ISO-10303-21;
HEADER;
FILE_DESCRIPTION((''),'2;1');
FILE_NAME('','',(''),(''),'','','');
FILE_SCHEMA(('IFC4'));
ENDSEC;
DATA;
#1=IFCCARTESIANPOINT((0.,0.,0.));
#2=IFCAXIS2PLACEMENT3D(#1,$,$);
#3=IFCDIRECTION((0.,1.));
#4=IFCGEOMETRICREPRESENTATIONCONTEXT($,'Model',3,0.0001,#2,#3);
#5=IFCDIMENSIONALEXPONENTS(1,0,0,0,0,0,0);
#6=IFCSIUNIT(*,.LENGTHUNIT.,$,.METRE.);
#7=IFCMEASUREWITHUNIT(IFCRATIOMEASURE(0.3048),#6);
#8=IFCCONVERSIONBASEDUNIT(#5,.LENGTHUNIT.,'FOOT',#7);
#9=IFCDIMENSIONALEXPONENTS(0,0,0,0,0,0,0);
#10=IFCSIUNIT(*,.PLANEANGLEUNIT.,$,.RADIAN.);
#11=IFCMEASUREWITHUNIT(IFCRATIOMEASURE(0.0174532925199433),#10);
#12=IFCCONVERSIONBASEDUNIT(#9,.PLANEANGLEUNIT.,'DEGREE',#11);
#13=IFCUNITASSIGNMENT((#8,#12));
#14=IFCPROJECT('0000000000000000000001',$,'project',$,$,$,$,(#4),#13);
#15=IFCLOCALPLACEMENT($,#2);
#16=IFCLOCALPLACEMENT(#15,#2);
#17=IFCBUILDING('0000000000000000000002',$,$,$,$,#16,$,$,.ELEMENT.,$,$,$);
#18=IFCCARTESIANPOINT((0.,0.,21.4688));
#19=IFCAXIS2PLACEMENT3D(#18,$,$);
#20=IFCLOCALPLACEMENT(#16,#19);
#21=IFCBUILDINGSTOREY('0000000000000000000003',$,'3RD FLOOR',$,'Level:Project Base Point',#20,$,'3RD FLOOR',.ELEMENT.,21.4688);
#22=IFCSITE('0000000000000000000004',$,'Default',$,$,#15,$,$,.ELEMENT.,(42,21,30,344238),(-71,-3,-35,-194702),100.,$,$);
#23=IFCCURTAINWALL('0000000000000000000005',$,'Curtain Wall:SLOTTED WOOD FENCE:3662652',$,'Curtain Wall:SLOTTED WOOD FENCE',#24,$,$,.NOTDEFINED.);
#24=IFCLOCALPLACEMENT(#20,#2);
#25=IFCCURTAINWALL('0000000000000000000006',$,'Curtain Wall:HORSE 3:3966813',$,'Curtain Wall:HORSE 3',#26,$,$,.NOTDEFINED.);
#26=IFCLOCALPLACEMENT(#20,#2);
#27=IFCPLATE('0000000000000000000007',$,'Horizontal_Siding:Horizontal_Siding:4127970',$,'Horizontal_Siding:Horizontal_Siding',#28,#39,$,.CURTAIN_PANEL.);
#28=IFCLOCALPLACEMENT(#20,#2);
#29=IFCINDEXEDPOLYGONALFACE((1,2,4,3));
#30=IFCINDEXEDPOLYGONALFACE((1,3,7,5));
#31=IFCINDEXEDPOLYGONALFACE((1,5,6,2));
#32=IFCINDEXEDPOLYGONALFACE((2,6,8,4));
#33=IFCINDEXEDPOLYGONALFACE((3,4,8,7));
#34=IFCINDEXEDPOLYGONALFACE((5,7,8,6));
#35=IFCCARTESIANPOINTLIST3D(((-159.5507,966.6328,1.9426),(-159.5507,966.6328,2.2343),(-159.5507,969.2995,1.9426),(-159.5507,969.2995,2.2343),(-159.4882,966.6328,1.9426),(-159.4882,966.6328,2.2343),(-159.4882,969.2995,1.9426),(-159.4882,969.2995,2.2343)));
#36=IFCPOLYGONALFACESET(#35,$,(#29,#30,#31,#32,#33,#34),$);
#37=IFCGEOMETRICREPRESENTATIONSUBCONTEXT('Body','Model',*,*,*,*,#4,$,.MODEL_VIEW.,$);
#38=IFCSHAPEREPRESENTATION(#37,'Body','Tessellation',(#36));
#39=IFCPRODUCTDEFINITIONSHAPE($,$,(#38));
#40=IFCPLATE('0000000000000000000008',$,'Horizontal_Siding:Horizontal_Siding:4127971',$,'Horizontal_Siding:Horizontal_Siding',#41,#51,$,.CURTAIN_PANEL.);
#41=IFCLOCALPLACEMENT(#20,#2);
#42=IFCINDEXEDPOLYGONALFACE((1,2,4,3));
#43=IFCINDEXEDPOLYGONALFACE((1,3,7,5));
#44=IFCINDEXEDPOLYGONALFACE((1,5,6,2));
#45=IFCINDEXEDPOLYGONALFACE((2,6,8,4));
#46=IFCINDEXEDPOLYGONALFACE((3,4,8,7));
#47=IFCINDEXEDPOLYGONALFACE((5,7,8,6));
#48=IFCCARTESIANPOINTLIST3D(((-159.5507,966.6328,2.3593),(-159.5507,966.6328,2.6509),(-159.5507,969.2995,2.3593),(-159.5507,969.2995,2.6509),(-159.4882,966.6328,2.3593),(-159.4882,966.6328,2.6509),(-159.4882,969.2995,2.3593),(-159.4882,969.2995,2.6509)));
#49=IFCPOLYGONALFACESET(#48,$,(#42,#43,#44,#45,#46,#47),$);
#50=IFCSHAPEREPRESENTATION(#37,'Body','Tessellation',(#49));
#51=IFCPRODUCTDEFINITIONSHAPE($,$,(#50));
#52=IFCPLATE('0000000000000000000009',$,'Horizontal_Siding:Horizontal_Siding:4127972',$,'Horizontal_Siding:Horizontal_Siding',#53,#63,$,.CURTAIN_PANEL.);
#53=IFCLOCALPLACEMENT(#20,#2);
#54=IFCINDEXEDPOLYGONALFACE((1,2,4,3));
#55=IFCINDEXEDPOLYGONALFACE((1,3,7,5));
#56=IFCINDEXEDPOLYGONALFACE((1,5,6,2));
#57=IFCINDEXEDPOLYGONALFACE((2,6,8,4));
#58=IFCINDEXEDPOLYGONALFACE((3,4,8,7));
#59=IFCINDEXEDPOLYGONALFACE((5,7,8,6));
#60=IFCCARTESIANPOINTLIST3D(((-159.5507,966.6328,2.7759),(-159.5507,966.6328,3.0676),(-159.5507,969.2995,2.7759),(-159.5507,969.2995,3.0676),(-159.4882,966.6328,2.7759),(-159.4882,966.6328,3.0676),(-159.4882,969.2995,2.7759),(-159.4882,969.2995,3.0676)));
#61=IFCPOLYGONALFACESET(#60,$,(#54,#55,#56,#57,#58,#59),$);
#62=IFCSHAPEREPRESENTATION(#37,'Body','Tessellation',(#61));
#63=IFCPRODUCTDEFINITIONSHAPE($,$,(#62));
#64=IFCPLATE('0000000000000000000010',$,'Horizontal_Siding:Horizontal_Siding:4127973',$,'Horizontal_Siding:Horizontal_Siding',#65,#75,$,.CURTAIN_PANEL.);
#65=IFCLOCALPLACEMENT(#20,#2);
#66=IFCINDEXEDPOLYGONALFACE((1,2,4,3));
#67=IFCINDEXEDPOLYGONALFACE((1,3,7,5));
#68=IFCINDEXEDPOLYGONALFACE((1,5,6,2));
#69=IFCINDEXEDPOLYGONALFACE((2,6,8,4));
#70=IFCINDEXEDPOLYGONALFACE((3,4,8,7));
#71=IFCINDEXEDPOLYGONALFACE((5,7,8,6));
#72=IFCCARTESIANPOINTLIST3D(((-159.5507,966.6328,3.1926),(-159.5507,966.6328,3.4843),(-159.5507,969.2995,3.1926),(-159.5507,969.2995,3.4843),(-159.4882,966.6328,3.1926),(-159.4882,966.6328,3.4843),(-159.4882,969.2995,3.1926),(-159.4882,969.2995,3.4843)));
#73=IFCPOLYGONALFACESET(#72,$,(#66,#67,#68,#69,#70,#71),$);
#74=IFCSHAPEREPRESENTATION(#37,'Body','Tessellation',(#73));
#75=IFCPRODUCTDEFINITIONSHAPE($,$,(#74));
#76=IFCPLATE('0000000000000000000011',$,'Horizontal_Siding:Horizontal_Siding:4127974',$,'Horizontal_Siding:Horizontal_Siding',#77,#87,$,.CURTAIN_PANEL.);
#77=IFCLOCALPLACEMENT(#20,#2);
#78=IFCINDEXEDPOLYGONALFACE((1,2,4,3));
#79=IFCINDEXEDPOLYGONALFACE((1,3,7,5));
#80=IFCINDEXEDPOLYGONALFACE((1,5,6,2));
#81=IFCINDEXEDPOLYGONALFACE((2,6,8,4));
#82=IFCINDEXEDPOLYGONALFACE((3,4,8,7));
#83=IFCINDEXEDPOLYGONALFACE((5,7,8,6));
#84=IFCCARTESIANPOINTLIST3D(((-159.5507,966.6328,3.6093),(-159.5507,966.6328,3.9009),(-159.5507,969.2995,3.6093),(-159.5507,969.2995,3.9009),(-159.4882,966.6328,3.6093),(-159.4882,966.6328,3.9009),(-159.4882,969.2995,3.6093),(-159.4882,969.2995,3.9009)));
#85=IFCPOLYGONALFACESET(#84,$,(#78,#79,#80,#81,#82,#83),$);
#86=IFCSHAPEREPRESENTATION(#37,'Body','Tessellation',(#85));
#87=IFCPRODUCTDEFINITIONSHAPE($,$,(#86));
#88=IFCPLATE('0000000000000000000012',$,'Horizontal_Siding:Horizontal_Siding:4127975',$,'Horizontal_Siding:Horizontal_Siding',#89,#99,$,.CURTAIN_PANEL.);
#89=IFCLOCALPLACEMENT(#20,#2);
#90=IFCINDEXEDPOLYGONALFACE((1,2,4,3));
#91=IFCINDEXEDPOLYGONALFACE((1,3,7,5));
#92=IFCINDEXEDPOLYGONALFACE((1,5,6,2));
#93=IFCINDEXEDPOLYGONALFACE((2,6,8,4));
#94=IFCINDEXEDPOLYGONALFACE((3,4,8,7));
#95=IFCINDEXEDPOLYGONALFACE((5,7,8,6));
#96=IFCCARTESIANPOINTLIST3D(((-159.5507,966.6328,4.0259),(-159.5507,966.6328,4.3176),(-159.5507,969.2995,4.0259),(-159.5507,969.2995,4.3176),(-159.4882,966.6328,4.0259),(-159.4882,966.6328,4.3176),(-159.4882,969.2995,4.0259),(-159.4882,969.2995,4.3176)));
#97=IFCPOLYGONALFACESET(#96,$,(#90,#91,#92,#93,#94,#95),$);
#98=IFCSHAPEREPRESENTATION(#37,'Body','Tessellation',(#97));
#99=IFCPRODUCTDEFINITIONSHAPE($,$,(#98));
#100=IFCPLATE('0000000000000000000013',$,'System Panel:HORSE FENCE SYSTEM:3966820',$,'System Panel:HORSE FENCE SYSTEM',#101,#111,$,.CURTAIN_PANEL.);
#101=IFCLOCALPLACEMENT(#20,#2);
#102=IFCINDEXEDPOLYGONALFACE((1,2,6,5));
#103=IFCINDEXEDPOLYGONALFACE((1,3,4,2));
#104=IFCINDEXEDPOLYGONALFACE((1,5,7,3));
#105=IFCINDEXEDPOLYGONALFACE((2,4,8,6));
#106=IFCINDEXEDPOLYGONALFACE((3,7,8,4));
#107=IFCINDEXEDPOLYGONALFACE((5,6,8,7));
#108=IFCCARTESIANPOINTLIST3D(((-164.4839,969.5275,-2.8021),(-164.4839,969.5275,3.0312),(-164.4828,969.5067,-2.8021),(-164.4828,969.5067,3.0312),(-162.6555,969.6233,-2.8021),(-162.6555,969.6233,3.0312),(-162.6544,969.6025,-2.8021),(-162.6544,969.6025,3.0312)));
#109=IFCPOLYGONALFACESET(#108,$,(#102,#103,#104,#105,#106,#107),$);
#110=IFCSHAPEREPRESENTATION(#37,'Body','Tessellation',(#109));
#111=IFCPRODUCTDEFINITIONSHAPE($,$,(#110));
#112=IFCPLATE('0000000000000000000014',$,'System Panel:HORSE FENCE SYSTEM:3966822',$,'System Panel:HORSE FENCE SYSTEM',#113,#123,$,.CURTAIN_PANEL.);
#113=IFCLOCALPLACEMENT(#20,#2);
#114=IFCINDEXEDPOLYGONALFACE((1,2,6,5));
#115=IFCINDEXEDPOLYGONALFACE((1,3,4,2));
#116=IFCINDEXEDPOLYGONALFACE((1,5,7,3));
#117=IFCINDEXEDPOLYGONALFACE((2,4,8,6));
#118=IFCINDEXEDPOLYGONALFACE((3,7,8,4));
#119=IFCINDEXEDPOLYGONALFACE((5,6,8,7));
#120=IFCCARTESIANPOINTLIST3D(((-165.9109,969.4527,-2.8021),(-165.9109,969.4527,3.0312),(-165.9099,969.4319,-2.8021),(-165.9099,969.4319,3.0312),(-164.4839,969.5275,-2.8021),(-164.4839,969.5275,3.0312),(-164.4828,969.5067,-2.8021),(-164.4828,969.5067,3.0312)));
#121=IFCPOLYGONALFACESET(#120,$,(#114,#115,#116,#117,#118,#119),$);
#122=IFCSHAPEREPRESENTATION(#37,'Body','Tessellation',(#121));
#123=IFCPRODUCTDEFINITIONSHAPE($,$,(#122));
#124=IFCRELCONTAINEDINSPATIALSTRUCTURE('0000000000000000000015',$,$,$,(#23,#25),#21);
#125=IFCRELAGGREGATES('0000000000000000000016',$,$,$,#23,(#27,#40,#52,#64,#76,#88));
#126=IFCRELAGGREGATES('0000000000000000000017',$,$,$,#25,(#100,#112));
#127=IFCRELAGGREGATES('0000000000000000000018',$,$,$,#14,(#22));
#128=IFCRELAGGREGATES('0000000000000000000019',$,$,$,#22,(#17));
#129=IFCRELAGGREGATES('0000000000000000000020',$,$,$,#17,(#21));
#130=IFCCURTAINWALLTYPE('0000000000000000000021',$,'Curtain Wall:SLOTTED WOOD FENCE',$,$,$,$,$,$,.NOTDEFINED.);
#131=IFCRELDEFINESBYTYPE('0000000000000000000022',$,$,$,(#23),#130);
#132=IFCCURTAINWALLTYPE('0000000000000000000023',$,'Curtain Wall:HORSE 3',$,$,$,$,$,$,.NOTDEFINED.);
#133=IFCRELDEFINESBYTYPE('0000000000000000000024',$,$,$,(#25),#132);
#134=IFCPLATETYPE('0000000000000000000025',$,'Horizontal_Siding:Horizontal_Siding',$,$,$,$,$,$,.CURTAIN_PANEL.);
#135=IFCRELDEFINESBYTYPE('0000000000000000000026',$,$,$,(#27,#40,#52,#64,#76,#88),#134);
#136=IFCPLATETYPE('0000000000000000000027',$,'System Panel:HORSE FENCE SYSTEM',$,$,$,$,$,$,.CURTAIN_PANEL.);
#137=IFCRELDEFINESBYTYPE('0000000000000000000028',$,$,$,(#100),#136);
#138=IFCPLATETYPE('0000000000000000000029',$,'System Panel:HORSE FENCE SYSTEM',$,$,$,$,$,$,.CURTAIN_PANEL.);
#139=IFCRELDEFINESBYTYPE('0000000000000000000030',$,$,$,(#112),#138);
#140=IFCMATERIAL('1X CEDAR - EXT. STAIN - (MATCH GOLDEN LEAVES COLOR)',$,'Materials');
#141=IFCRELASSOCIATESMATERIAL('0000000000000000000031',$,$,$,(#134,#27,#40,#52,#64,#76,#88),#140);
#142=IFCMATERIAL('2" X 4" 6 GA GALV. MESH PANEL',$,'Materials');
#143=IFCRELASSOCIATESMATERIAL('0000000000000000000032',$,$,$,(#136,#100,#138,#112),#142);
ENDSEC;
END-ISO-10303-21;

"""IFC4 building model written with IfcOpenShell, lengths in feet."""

from ifc_helpers import new_model, entity, si_unit, converted_unit, direction, frame, frame_2d, origin, origin_2d_with_axis, place, context, subcontext, project, spatial, rectangle, extrude, source, transform, mapped, material, type_object, type_shapes, element, aggregate, save


model = new_model("IFC4")

# Units and contexts
model_context = context("Model", 3, precision=0.0001, world=origin(), true_north=direction((0.0, 1.0)))
body_context = subcontext(model_context, "Body", "Model", "MODEL_VIEW")
ifc_project = project(units=[converted_unit("LENGTHUNIT", "FOOT", entity("IfcRatioMeasure", 0.3048), si_unit("LENGTHUNIT", "METRE"), dimensions=[1, 0, 0, 0, 0, 0, 0]), converted_unit("PLANEANGLEUNIT", "DEGREE", entity("IfcRatioMeasure", 0.0174532925199433), si_unit("PLANEANGLEUNIT", "RADIAN"), dimensions=[0, 0, 0, 0, 0, 0, 0])], contexts=[model_context])

# Site, building, storey
site_placement = place(None, origin())
site = spatial("IfcSite", under=ifc_project, at=site_placement, Name="Default", CompositionType="ELEMENT", RefLatitude=(42, 21, 30, 344238), RefLongitude=(-71, -3, -35, -194702), RefElevation=100.0)
building_placement = place(site_placement, origin())
building = spatial("IfcBuilding", under=site, at=building_placement, CompositionType="ELEMENT")
storey_placement = place(building_placement, frame((0.0, 0.0, 21.4688)))
storey = spatial("IfcBuildingStorey", under=building, at=storey_placement, Name="3RD FLOOR", ObjectType="Level:Project Base Point", LongName="3RD FLOOR", CompositionType="ELEMENT", Elevation=21.4688)

# Curtain wall
curtain_wall_type_1 = type_object("IfcCurtainWallType", Name="Curtain Wall:SLOTTED WOOD FENCE", PredefinedType="NOTDEFINED")
curtain_wall_1_placement = place(storey_placement, frame((0.0, 0.0, -21.4688)))
curtain_wall_1 = element("IfcCurtainWall", 1, at=curtain_wall_1_placement, inside=storey, type_object=curtain_wall_type_1, Name="Curtain Wall:SLOTTED WOOD FENCE:3662652", ObjectType="Curtain Wall:SLOTTED WOOD FENCE", PredefinedType="NOTDEFINED")

# Curtain wall
curtain_wall_type_2 = type_object("IfcCurtainWallType", Name="Curtain Wall:HORSE 3", PredefinedType="NOTDEFINED")
curtain_wall_2_placement = place(storey_placement, frame((0.0, 0.0, -21.4688)))
curtain_wall_2 = element("IfcCurtainWall", 2, at=curtain_wall_2_placement, inside=storey, type_object=curtain_wall_type_2, Name="Curtain Wall:HORSE 3:3966813", ObjectType="Curtain Wall:HORSE 3", PredefinedType="NOTDEFINED")

# Plates
ifc_material_1 = material(Name="1X CEDAR - EXT. STAIN - (MATCH GOLDEN LEAVES COLOR)", Category="Materials")
plate_type_1 = type_object("IfcPlateType", Name="Horizontal_Siding:Horizontal_Siding", PredefinedType="CURTAIN_PANEL", material=ifc_material_1)
shared_shape_1 = source(origin(), body_context, "Body", "SweptSolid", [
    extrude(rectangle(XDim=2.6667, YDim=0.0625, at=origin_2d_with_axis()), frame((1.3333, 0.0312, 0.0), z_axis=(0.0, 0.0, 1.0), x_axis=(-1.0, 0.0, 0.0)), (0.0, 0.0, 1.0), 0.2917),
])
type_shapes(plate_type_1, [shared_shape_1])
plate_1_placement = place(curtain_wall_1_placement, frame((-159.5507, 969.2995, 23.4113), z_axis=(0.0, 0.0, 1.0), x_axis=(0.0, -1.0, 0.0)))
plate_1 = element("IfcPlate", 3, at=plate_1_placement, type_object=plate_type_1, material=ifc_material_1, Name="Horizontal_Siding:Horizontal_Siding:4127970", ObjectType="Horizontal_Siding:Horizontal_Siding", PredefinedType="CURTAIN_PANEL", context=body_context, shape_type="MappedRepresentation", body=[
    mapped(shared_shape_1, transform((0.0, 0.0, 0.0), scale=1.0)),
])
plate_2_placement = place(curtain_wall_1_placement, frame((-159.5507, 969.2995, 23.828), z_axis=(0.0, 0.0, 1.0), x_axis=(0.0, -1.0, 0.0)))
plate_2 = element("IfcPlate", 4, at=plate_2_placement, type_object=plate_type_1, material=ifc_material_1, Name="Horizontal_Siding:Horizontal_Siding:4127971", ObjectType="Horizontal_Siding:Horizontal_Siding", PredefinedType="CURTAIN_PANEL", context=body_context, shape_type="MappedRepresentation", body=[
    mapped(shared_shape_1, transform((0.0, 0.0, 0.0), scale=1.0)),
])
plate_3_placement = place(curtain_wall_1_placement, frame((-159.5507, 969.2995, 24.2447), z_axis=(0.0, 0.0, 1.0), x_axis=(0.0, -1.0, 0.0)))
plate_3 = element("IfcPlate", 5, at=plate_3_placement, type_object=plate_type_1, material=ifc_material_1, Name="Horizontal_Siding:Horizontal_Siding:4127972", ObjectType="Horizontal_Siding:Horizontal_Siding", PredefinedType="CURTAIN_PANEL", context=body_context, shape_type="MappedRepresentation", body=[
    mapped(shared_shape_1, transform((0.0, 0.0, 0.0), scale=1.0)),
])
plate_4_placement = place(curtain_wall_1_placement, frame((-159.5507, 969.2995, 24.6613), z_axis=(0.0, 0.0, 1.0), x_axis=(0.0, -1.0, 0.0)))
plate_4 = element("IfcPlate", 6, at=plate_4_placement, type_object=plate_type_1, material=ifc_material_1, Name="Horizontal_Siding:Horizontal_Siding:4127973", ObjectType="Horizontal_Siding:Horizontal_Siding", PredefinedType="CURTAIN_PANEL", context=body_context, shape_type="MappedRepresentation", body=[
    mapped(shared_shape_1, transform((0.0, 0.0, 0.0), scale=1.0)),
])
plate_5_placement = place(curtain_wall_1_placement, frame((-159.5507, 969.2995, 25.078), z_axis=(0.0, 0.0, 1.0), x_axis=(0.0, -1.0, 0.0)))
plate_5 = element("IfcPlate", 7, at=plate_5_placement, type_object=plate_type_1, material=ifc_material_1, Name="Horizontal_Siding:Horizontal_Siding:4127974", ObjectType="Horizontal_Siding:Horizontal_Siding", PredefinedType="CURTAIN_PANEL", context=body_context, shape_type="MappedRepresentation", body=[
    mapped(shared_shape_1, transform((0.0, 0.0, 0.0), scale=1.0)),
])
plate_6_placement = place(curtain_wall_1_placement, frame((-159.5507, 969.2995, 25.4947), z_axis=(0.0, 0.0, 1.0), x_axis=(0.0, -1.0, 0.0)))
plate_6 = element("IfcPlate", 8, at=plate_6_placement, type_object=plate_type_1, material=ifc_material_1, Name="Horizontal_Siding:Horizontal_Siding:4127975", ObjectType="Horizontal_Siding:Horizontal_Siding", PredefinedType="CURTAIN_PANEL", context=body_context, shape_type="MappedRepresentation", body=[
    mapped(shared_shape_1, transform((0.0, 0.0, 0.0), scale=1.0)),
])
aggregate(curtain_wall_1, [plate_1, plate_2, plate_3, plate_4, plate_5, plate_6])
ifc_material_2 = material(Name="2\" X 4\" 6 GA GALV. MESH PANEL", Category="Materials")
plate_type_2 = type_object("IfcPlateType", Name="System Panel:HORSE FENCE SYSTEM", PredefinedType="CURTAIN_PANEL", material=ifc_material_2)
shared_shape_2 = source(origin(), body_context, "Body", "SweptSolid", [
    extrude(rectangle(XDim=0.0208, YDim=1.8308, at=frame_2d((0.0, 0.0), x_axis=(1.0, 0.0))), frame((0.9154, 0.0104, 0.0), z_axis=(0.0, 0.0, 1.0), x_axis=(0.0, 1.0, 0.0)), (0.0, 0.0, 1.0), 5.8333),
])
type_shapes(plate_type_2, [shared_shape_2])
plate_7_placement = place(curtain_wall_2_placement, frame((-162.6555, 969.6233, 18.6667), z_axis=(0.0, 0.0, 1.0), x_axis=(-0.99863, -0.052336, 0.0)))
plate_7 = element("IfcPlate", 9, at=plate_7_placement, type_object=plate_type_2, material=ifc_material_2, Name="System Panel:HORSE FENCE SYSTEM:3966820", ObjectType="System Panel:HORSE FENCE SYSTEM", PredefinedType="CURTAIN_PANEL", context=body_context, shape_type="MappedRepresentation", body=[
    mapped(shared_shape_2, transform((0.0, 0.0, 0.0), scale=1.0)),
])
plate_type_3 = type_object("IfcPlateType", Name="System Panel:HORSE FENCE SYSTEM", PredefinedType="CURTAIN_PANEL", material=ifc_material_2)
shared_shape_3 = source(origin(), body_context, "Body", "SweptSolid", [
    extrude(rectangle(XDim=0.0208, YDim=1.429, at=frame_2d((0.0, 0.0), x_axis=(1.0, 0.0))), frame((0.7145, 0.0104, 0.0), z_axis=(0.0, 0.0, 1.0), x_axis=(0.0, 1.0, 0.0)), (0.0, 0.0, 1.0), 5.8333),
])
type_shapes(plate_type_3, [shared_shape_3])
plate_8_placement = place(curtain_wall_2_placement, frame((-164.4839, 969.5275, 18.6667), z_axis=(0.0, 0.0, 1.0), x_axis=(-0.99863, -0.052336, 0.0)))
plate_8 = element("IfcPlate", 10, at=plate_8_placement, type_object=plate_type_3, material=ifc_material_2, Name="System Panel:HORSE FENCE SYSTEM:3966822", ObjectType="System Panel:HORSE FENCE SYSTEM", PredefinedType="CURTAIN_PANEL", context=body_context, shape_type="MappedRepresentation", body=[
    mapped(shared_shape_3, transform((0.0, 0.0, 0.0), scale=1.0)),
])
aggregate(curtain_wall_2, [plate_7, plate_8])

save(model, "model.ifc")
